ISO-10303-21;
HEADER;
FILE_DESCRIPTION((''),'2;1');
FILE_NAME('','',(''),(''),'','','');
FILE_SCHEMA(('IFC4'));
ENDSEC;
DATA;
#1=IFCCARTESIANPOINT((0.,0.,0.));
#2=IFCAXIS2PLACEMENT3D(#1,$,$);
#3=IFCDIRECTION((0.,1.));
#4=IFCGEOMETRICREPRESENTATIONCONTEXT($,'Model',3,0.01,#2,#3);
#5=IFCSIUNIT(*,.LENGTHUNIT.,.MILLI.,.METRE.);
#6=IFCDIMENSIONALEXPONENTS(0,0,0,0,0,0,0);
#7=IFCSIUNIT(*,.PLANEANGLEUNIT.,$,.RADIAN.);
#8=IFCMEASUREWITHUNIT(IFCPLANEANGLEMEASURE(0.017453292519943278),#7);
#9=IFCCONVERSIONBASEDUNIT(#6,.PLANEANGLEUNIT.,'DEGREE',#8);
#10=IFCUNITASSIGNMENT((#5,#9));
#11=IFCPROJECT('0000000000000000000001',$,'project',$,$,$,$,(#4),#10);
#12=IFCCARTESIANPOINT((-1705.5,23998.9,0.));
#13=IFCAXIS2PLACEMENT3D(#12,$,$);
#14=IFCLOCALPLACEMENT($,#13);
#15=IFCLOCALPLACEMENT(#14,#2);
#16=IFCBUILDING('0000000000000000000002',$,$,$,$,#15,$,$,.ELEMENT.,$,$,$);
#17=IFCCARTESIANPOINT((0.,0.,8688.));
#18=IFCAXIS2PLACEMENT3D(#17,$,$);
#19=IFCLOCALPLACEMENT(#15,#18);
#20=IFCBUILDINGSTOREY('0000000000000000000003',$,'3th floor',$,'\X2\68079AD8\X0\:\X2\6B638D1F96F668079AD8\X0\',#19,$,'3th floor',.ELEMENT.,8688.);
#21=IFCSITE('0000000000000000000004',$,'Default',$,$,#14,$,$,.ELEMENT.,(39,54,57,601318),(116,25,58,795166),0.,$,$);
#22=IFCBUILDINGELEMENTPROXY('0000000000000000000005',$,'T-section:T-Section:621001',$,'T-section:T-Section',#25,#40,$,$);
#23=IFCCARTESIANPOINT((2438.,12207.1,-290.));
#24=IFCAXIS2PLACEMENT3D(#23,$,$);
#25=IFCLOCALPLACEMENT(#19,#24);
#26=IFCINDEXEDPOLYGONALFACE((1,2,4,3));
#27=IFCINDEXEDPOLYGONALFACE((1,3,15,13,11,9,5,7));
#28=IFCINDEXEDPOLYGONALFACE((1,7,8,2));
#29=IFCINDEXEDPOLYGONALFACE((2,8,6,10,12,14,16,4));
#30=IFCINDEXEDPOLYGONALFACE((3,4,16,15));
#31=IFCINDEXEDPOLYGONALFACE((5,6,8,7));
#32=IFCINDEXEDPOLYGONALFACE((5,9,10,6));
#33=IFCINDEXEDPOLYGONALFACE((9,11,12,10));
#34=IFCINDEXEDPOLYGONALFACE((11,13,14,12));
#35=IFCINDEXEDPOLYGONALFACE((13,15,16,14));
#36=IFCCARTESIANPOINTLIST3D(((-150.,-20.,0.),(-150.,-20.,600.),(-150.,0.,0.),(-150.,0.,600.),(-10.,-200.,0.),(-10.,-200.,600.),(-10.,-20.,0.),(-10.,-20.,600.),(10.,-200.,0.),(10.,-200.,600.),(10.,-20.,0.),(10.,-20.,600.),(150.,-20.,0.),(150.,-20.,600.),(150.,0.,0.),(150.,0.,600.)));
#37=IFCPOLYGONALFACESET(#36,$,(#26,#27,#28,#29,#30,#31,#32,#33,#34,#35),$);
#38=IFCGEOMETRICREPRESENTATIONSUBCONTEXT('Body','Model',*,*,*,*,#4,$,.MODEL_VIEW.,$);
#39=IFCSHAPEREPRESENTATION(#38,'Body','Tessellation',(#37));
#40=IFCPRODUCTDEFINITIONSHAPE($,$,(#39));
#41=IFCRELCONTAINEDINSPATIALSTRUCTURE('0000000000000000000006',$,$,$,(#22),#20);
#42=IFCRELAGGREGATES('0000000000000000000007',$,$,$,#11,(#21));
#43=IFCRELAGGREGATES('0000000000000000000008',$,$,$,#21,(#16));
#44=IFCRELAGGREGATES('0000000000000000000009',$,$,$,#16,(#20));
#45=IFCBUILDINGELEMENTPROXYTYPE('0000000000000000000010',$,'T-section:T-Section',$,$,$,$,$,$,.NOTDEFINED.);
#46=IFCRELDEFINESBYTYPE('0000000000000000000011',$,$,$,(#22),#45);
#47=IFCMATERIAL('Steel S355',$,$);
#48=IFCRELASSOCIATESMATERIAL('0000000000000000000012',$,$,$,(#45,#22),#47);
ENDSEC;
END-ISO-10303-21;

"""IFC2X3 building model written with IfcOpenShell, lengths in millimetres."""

from ifc_helpers import new_model, entity, si_unit, converted_unit, direction, frame, origin, place, context, subcontext, project, spatial, polyline, outline, extrude, source, transform, mapped, material, type_object, type_shapes, element, save


model = new_model("IFC2X3")

# Units and contexts
model_context = context("Model", 3, precision=0.01, world=origin(), true_north=direction((0.0, 1.0)))
body_context = subcontext(model_context, "Body", "Model", "MODEL_VIEW")
ifc_project = project(units=[si_unit("LENGTHUNIT", "METRE", prefix="MILLI"), converted_unit("PLANEANGLEUNIT", "DEGREE", entity("IfcPlaneAngleMeasure", 0.017453292519943278), si_unit("PLANEANGLEUNIT", "RADIAN"), dimensions=[0, 0, 0, 0, 0, 0, 0])], contexts=[model_context])

# Site, building, storey
site_placement = place(None, frame((-1705.5, 23998.9, 0.0)))
site = spatial("IfcSite", under=ifc_project, at=site_placement, Name="Default", CompositionType="ELEMENT", RefLatitude=(39, 54, 57, 601318), RefLongitude=(116, 25, 58, 795166), RefElevation=0.0)
building_placement = place(site_placement, origin())
building = spatial("IfcBuilding", under=site, at=building_placement, CompositionType="ELEMENT")
storey_placement = place(building_placement, frame((0.0, 0.0, 8688.0)))
storey = spatial("IfcBuildingStorey", under=building, at=storey_placement, Name="3th floor", ObjectType="标高:正负零标高", LongName="3th floor", CompositionType="ELEMENT", Elevation=8688.0)

# Shared definitions
ifc_material_1 = material(Name="Steel S355")

# Building element proxy
building_element_proxy_type_1 = type_object("IfcBuildingElementProxyType", Name="T-section:T-Section", PredefinedType="NOTDEFINED", material=ifc_material_1)
shared_shape_1 = source(origin(), body_context, "Body", "SweptSolid", [
    extrude(outline(polyline([(-10.0, -140.0), (10.0, -140.0), (10.0, 40.0), (150.0, 40.0), (150.0, 60.0), (-150.0, 60.0), (-150.0, 40.0), (-10.0, 40.0), (-10.0, -140.0)])), frame((0.0, -60.0, 0.0)), (0.0, 0.0, 1.0), 600.0),
])
type_shapes(building_element_proxy_type_1, [shared_shape_1])
proxy_placement = place(storey_placement, frame((2438.0, 12207.1, -290.0)))
element("IfcBuildingElementProxy", 1, at=proxy_placement, inside=storey, type_object=building_element_proxy_type_1, material=ifc_material_1, Name="T-section:T-Section:621001", ObjectType="T-section:T-Section", context=body_context, shape_type="MappedRepresentation", body=[
    mapped(shared_shape_1, transform((0.0, 0.0, 0.0), scale=1.0)),
])

save(model, "model.ifc")
